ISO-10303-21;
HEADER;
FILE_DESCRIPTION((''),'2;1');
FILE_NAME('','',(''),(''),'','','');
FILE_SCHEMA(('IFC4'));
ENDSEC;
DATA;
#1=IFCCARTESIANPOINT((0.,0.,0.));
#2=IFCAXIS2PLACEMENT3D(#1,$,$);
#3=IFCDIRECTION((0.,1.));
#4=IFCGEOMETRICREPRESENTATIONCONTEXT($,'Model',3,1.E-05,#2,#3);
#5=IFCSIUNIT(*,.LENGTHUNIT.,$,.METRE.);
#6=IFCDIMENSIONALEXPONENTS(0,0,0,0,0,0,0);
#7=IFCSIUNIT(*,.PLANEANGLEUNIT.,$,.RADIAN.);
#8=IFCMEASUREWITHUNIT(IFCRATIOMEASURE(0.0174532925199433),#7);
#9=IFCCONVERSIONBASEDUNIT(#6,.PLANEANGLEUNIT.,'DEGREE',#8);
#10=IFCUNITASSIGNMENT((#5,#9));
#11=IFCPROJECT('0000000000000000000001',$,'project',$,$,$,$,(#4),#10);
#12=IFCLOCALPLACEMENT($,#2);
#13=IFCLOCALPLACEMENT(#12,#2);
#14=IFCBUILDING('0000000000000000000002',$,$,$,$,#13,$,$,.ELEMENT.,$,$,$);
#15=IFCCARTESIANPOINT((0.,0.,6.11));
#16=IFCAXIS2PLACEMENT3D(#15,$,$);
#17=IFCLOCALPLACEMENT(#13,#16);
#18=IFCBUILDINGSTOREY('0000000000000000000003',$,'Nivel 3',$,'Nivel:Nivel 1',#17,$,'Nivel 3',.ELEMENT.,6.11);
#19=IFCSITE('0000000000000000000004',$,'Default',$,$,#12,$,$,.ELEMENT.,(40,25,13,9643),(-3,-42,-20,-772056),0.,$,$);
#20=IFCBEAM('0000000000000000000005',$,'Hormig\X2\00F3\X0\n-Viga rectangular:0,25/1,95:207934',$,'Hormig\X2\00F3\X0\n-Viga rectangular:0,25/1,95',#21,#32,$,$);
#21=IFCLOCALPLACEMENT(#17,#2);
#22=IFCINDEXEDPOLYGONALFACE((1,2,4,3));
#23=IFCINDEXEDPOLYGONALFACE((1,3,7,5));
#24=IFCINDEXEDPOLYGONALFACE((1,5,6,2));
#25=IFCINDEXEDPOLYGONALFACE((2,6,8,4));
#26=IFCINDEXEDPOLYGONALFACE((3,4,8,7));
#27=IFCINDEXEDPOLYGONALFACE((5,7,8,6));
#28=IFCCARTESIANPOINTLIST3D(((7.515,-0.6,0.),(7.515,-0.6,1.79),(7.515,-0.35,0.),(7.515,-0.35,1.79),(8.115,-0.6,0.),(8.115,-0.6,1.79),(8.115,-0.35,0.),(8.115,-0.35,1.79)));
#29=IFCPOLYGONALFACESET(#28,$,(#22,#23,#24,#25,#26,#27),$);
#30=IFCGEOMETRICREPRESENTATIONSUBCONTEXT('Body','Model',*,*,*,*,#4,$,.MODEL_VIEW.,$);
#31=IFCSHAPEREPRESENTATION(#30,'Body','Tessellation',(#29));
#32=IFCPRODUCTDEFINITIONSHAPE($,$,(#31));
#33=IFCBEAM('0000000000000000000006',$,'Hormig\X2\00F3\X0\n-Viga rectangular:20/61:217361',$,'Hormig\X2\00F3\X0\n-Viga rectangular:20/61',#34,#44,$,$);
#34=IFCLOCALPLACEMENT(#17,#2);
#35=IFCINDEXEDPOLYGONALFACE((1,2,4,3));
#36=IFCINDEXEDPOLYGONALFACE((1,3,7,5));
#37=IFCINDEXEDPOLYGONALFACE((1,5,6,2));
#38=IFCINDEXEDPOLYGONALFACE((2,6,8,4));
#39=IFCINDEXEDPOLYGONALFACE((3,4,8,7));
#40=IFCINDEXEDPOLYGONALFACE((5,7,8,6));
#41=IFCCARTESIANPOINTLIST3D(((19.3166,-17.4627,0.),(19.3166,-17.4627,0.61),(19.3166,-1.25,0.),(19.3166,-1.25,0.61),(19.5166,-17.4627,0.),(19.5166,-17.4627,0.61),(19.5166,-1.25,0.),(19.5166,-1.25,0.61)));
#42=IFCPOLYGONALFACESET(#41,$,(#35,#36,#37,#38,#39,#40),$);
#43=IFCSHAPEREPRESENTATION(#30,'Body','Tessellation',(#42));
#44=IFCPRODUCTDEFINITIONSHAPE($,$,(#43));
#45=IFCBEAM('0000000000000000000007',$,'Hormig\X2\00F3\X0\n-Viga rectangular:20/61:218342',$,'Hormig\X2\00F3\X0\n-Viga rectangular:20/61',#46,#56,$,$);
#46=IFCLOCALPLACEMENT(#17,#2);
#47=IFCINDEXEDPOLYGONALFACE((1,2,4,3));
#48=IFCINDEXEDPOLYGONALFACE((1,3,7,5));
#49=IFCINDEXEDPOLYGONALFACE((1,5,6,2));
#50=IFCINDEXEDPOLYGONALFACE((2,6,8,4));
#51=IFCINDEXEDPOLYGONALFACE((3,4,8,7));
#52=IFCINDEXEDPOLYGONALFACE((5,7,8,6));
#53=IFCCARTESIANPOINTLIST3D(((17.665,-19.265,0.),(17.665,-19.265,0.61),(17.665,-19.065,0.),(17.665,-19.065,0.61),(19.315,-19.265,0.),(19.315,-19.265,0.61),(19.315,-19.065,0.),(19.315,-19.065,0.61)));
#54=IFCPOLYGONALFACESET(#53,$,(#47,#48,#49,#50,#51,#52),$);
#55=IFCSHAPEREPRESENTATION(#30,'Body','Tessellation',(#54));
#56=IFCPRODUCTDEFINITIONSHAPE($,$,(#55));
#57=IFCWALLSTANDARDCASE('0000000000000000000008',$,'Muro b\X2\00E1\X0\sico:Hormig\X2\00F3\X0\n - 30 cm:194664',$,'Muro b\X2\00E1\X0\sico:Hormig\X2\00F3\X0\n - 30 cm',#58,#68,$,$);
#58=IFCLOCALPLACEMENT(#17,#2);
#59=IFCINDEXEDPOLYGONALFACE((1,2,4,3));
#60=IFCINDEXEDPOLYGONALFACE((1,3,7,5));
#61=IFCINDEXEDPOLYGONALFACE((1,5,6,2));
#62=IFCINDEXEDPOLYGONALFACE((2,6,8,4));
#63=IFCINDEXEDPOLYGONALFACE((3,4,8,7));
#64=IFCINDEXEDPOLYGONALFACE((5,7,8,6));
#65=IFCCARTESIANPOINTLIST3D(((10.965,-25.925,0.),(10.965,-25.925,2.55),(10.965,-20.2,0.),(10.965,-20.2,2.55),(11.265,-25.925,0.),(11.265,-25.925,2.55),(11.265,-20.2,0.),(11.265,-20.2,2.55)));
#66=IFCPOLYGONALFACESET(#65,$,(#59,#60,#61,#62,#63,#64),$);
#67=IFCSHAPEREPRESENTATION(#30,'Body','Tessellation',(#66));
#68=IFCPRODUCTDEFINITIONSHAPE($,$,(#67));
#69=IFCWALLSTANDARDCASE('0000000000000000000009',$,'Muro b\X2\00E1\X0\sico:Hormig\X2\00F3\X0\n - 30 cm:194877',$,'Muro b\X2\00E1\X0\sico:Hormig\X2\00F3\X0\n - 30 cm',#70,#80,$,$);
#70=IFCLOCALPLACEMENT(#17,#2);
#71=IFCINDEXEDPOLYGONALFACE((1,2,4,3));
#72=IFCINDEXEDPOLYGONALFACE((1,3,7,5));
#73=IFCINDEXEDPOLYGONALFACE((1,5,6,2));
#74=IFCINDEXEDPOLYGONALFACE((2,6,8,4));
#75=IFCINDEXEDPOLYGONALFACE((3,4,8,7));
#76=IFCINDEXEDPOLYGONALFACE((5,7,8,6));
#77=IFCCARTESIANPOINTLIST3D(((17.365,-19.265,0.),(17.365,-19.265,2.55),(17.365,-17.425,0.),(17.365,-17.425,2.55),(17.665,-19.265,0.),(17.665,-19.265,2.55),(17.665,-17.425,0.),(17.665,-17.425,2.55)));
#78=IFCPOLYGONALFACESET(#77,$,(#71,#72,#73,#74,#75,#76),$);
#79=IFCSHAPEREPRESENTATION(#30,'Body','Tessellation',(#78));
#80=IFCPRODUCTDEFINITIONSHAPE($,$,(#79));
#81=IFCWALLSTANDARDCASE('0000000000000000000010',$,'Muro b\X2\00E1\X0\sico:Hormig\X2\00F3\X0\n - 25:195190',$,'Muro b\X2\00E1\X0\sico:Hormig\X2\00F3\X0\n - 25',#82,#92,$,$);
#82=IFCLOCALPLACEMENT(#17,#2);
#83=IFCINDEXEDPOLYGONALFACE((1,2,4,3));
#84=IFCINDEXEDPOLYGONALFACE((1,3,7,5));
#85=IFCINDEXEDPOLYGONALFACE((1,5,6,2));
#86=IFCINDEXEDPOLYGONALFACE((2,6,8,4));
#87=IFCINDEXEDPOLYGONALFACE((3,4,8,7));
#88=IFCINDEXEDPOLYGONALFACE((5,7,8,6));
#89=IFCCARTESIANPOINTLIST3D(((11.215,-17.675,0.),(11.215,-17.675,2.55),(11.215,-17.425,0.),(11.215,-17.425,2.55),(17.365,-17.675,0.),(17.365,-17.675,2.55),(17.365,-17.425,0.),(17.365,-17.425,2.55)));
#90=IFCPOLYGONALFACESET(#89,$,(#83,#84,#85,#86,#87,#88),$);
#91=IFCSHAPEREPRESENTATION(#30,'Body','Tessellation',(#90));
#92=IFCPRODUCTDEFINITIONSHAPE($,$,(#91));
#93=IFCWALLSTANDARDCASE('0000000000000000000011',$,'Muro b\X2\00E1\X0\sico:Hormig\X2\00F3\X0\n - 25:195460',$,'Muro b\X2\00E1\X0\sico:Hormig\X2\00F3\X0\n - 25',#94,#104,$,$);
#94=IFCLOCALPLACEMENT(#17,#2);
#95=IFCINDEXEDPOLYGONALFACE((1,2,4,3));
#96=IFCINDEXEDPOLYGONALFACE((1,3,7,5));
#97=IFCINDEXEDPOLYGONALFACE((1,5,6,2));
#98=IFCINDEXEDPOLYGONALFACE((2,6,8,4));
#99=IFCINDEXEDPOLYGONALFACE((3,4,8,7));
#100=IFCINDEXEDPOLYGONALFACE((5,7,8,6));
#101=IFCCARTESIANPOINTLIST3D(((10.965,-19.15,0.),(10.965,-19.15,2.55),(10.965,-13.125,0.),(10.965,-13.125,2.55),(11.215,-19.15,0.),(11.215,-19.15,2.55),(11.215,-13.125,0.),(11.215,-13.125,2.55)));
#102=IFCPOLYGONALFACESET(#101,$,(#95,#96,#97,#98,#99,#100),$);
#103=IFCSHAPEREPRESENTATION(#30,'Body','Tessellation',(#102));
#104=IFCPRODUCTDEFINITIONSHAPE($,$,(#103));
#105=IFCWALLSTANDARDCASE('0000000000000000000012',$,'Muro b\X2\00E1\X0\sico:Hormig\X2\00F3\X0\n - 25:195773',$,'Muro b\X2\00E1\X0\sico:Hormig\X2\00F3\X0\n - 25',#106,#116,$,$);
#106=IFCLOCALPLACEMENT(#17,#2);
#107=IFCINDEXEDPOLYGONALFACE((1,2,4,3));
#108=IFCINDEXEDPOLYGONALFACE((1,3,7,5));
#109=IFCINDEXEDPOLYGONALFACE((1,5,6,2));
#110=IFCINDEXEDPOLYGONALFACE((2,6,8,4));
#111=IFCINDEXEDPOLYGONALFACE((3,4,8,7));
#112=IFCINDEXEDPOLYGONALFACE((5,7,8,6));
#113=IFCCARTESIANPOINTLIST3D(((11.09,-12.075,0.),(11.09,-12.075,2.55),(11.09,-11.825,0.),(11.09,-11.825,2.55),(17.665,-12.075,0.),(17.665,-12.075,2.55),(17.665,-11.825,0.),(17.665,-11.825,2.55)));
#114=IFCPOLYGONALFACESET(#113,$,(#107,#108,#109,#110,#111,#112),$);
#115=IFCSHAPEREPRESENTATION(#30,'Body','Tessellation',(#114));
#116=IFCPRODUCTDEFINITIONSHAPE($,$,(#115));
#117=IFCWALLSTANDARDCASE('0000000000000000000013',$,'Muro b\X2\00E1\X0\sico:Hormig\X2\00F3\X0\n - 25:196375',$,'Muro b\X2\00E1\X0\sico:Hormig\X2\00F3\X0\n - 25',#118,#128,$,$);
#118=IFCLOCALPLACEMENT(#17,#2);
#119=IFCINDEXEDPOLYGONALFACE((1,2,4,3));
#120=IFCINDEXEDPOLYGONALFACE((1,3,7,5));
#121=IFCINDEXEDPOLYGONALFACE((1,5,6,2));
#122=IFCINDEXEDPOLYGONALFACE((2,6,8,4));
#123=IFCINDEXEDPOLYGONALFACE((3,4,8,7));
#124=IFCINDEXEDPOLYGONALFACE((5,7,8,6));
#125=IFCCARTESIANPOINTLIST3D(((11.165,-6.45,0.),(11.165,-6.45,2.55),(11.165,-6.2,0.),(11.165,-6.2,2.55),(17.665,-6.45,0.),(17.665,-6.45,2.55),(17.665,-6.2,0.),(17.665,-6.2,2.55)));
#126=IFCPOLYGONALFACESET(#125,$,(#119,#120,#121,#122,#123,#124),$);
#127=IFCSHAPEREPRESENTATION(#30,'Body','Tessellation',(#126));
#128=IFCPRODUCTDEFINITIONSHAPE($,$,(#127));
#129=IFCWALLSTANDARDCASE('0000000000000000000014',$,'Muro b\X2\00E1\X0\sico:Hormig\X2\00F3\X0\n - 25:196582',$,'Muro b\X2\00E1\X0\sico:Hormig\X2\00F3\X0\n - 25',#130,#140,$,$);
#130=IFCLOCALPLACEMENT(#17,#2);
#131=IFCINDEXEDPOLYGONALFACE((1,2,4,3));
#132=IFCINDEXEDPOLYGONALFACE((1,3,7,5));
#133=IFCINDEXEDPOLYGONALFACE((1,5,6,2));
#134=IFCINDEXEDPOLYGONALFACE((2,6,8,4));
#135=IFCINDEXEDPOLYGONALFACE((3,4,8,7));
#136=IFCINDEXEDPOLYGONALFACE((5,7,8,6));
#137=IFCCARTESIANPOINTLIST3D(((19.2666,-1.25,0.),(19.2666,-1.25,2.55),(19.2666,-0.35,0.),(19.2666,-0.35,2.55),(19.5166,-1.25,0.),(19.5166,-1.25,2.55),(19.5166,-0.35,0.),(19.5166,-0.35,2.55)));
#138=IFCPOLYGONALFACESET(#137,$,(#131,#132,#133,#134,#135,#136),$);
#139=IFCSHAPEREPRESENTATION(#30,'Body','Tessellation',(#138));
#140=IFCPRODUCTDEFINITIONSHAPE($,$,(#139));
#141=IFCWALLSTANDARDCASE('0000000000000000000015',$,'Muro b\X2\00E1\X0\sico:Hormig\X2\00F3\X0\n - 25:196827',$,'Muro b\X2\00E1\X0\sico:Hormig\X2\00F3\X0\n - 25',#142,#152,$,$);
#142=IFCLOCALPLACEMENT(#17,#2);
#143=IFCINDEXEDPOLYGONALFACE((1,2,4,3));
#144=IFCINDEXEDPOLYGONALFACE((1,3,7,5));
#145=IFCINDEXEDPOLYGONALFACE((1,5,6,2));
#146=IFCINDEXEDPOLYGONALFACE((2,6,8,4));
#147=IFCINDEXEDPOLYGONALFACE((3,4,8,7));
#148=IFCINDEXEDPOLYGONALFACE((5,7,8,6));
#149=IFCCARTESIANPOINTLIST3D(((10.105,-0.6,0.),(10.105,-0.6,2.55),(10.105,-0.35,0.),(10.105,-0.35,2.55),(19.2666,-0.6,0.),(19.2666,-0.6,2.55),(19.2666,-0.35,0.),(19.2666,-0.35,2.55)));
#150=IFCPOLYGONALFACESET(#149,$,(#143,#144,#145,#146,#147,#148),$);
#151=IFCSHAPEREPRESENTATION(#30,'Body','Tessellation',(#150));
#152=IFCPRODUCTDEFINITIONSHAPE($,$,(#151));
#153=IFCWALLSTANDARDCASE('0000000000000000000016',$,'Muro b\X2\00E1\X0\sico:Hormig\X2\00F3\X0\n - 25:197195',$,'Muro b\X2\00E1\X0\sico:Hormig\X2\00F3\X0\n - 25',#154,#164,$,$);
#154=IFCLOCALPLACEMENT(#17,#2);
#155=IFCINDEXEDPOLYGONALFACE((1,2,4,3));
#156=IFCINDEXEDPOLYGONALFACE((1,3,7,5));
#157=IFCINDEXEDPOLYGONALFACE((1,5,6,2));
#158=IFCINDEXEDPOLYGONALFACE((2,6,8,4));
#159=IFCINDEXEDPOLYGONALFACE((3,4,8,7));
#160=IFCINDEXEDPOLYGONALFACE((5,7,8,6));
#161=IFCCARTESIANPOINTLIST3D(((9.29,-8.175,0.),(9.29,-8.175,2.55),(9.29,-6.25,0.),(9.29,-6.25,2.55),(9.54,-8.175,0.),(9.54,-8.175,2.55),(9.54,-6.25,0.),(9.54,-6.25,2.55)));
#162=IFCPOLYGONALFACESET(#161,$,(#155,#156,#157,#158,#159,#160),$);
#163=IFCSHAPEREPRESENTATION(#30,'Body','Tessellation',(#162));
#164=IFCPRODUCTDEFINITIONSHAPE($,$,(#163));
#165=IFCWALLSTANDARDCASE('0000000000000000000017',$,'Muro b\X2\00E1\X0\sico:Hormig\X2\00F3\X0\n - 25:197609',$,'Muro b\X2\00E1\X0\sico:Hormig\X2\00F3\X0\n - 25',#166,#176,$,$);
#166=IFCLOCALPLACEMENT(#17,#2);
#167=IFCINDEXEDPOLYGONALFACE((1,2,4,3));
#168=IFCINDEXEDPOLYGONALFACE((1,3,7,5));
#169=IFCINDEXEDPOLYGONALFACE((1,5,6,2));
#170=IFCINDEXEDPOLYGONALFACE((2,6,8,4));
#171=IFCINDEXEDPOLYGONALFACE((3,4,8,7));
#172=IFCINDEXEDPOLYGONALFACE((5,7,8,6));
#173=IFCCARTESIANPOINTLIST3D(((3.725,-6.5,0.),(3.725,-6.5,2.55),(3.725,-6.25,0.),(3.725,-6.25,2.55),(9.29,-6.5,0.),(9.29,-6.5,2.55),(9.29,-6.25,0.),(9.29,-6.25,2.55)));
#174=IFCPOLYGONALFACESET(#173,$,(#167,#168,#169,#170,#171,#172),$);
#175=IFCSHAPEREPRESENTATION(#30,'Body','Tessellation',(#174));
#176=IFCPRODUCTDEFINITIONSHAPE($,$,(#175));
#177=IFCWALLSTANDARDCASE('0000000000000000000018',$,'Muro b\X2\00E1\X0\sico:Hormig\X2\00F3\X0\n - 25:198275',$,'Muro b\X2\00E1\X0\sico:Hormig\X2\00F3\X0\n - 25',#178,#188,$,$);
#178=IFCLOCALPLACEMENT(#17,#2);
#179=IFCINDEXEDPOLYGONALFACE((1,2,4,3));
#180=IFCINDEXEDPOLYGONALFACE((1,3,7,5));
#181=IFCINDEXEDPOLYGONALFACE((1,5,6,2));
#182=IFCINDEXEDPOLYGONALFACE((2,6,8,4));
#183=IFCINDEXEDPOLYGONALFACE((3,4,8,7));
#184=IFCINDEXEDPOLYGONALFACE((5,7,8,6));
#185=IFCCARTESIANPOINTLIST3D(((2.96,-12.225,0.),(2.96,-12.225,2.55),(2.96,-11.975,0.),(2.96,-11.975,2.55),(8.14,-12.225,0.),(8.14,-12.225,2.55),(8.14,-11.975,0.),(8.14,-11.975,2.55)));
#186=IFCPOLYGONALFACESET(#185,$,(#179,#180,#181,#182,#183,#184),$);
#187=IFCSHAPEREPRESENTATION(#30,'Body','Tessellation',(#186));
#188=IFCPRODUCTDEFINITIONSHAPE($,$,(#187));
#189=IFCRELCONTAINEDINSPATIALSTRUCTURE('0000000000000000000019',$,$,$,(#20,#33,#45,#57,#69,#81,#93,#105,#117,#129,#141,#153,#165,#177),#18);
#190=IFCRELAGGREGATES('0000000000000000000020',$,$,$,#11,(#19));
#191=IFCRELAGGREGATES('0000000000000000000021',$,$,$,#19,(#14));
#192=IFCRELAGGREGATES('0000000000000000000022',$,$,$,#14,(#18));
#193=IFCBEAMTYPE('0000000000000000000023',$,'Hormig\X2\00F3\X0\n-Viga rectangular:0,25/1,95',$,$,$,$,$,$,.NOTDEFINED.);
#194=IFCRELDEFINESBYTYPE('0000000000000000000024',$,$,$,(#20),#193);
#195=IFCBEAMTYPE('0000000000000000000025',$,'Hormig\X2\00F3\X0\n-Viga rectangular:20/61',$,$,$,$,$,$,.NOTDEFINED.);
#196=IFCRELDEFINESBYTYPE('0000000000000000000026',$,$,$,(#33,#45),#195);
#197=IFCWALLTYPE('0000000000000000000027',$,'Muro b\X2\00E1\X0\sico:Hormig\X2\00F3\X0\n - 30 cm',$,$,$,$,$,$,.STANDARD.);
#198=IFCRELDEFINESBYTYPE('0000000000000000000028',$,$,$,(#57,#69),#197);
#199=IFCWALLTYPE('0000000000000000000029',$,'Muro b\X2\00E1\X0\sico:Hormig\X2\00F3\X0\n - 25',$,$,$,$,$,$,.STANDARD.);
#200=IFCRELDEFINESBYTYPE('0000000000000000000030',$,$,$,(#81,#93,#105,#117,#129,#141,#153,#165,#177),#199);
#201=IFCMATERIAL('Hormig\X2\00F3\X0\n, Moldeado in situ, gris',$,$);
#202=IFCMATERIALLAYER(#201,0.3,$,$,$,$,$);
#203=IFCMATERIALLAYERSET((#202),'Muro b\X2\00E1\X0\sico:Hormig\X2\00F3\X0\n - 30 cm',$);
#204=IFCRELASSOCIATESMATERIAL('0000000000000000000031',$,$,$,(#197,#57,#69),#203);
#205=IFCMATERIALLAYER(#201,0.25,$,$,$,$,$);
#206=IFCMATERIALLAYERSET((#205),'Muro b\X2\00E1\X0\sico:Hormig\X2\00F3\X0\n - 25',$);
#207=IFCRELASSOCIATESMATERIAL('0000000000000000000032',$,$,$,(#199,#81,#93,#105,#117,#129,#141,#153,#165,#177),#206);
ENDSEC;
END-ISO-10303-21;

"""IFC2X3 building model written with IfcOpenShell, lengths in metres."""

from ifc_helpers import new_model, entity, si_unit, converted_unit, direction, frame, frame_2d, origin, origin_2d_with_axis, place, context, subcontext, project, spatial, rectangle, extrude, material, layer, layer_set, layer_usage, type_object, element, save


model = new_model("IFC2X3")

# Units and contexts
model_context = context("Model", 3, precision=1e-05, world=origin(), true_north=direction((0.0, 1.0)))
body_context = subcontext(model_context, "Body", "Model", "MODEL_VIEW")
ifc_project = project(units=[si_unit("LENGTHUNIT", "METRE"), converted_unit("PLANEANGLEUNIT", "DEGREE", entity("IfcRatioMeasure", 0.0174532925199433), si_unit("PLANEANGLEUNIT", "RADIAN"), dimensions=[0, 0, 0, 0, 0, 0, 0])], contexts=[model_context])

# Site, building, storey
site_placement = place(None, origin())
site = spatial("IfcSite", under=ifc_project, at=site_placement, Name="Default", CompositionType="ELEMENT", RefLatitude=(40, 25, 13, 9643), RefLongitude=(-3, -42, -20, -772056), RefElevation=0.0)
building_placement = place(site_placement, origin())
building = spatial("IfcBuilding", under=site, at=building_placement, CompositionType="ELEMENT")
storey_placement = place(building_placement, frame((0.0, 0.0, 6.11)))
storey = spatial("IfcBuildingStorey", under=building, at=storey_placement, Name="Nivel 3", ObjectType="Nivel:Nivel 1", LongName="Nivel 3", CompositionType="ELEMENT", Elevation=6.11)

# Beams
beam_type_1 = type_object("IfcBeamType", Name="Hormigón-Viga rectangular:0,25/1,95", PredefinedType="NOTDEFINED")
beam_1_placement = place(storey_placement, frame((7.515, -0.475, 1.79)))
element("IfcBeam", 1, at=beam_1_placement, inside=storey, type_object=beam_type_1, Name="Hormigón-Viga rectangular:0,25/1,95:207934", ObjectType="Hormigón-Viga rectangular:0,25/1,95", context=body_context, shape_type="SweptSolid", body=[
    extrude(rectangle(XDim=1.79, YDim=0.25, at=frame_2d((0.0, 0.0), x_axis=(1.0, 0.0))), frame((0.0, 0.0, -0.895), z_axis=(1.0, 0.0, 0.0), x_axis=(0.0, 0.0, -1.0)), (0.0, 0.0, 1.0), 0.6),
])
beam_type_2 = type_object("IfcBeamType", Name="Hormigón-Viga rectangular:20/61", PredefinedType="NOTDEFINED")
beam_2_placement = place(storey_placement, frame((19.4166, -17.45, 0.61), z_axis=(0.0, 0.0, 1.0), x_axis=(0.0, 1.0, 0.0)))
element("IfcBeam", 2, at=beam_2_placement, inside=storey, type_object=beam_type_2, Name="Hormigón-Viga rectangular:20/61:217361", ObjectType="Hormigón-Viga rectangular:20/61", context=body_context, shape_type="SweptSolid", body=[
    extrude(rectangle(XDim=0.61, YDim=0.2, at=origin_2d_with_axis()), frame((-0.0127, 0.0, -0.305), z_axis=(1.0, 0.0, 0.0), x_axis=(0.0, 0.0, -1.0)), (0.0, 0.0, 1.0), 16.2127),
])
beam_3_placement = place(storey_placement, frame((17.515, -19.165, 0.61)))
element("IfcBeam", 3, at=beam_3_placement, inside=storey, type_object=beam_type_2, Name="Hormigón-Viga rectangular:20/61:218342", ObjectType="Hormigón-Viga rectangular:20/61", context=body_context, shape_type="SweptSolid", body=[
    extrude(rectangle(XDim=0.61, YDim=0.2, at=frame_2d((0.0, 0.0), x_axis=(1.0, 0.0))), frame((0.15, 0.0, -0.305), z_axis=(1.0, 0.0, 0.0), x_axis=(0.0, 0.0, -1.0)), (0.0, 0.0, 1.0), 1.65),
])

# Walls
ifc_material = material(Name="Hormigón, Moldeado in situ, gris")
ifc_layer_1 = layer(ifc_material, 0.3)
ifc_layer_set_1 = layer_set([ifc_layer_1], Name="Muro básico:Hormigón - 30 cm")
ifc_layer_usage_1 = layer_usage(ifc_layer_set_1, "AXIS2", "NEGATIVE", 0.15)
wall_type_1 = type_object("IfcWallType", Name="Muro básico:Hormigón - 30 cm", PredefinedType="STANDARD", material=ifc_layer_set_1)
wall_1_placement = place(storey_placement, frame((11.115, -20.2, 0.0), z_axis=(0.0, 0.0, 1.0), x_axis=(0.0, -1.0, 0.0)))
element("IfcWallStandardCase", 4, at=wall_1_placement, inside=storey, type_object=wall_type_1, material=ifc_layer_usage_1, Name="Muro básico:Hormigón - 30 cm:194664", ObjectType="Muro básico:Hormigón - 30 cm", context=body_context, shape_type="SweptSolid", body=[
    extrude(rectangle(XDim=5.725, YDim=0.3, at=frame_2d((2.8625, 0.0), x_axis=(-1.0, 0.0))), origin(), (0.0, 0.0, 1.0), 2.55),
])
ifc_layer_usage_2 = layer_usage(ifc_layer_set_1, "AXIS2", "NEGATIVE", 0.15)
wall_2_placement = place(storey_placement, frame((17.515, -19.265, 0.0), z_axis=(0.0, 0.0, 1.0), x_axis=(0.0, 1.0, 0.0)))
element("IfcWallStandardCase", 5, at=wall_2_placement, inside=storey, type_object=wall_type_1, material=ifc_layer_usage_2, Name="Muro básico:Hormigón - 30 cm:194877", ObjectType="Muro básico:Hormigón - 30 cm", context=body_context, shape_type="SweptSolid", body=[
    extrude(rectangle(XDim=1.84, YDim=0.3, at=frame_2d((0.92, 0.0), x_axis=(-1.0, 0.0))), origin(), (0.0, 0.0, 1.0), 2.55),
])
ifc_layer_2 = layer(ifc_material, 0.25)
ifc_layer_set_2 = layer_set([ifc_layer_2], Name="Muro básico:Hormigón - 25")
ifc_layer_usage_3 = layer_usage(ifc_layer_set_2, "AXIS2", "NEGATIVE", 0.125)
wall_type_2 = type_object("IfcWallType", Name="Muro básico:Hormigón - 25", PredefinedType="STANDARD", material=ifc_layer_set_2)
wall_3_placement = place(storey_placement, frame((17.365, -17.55, 0.0), z_axis=(0.0, 0.0, 1.0), x_axis=(-1.0, 0.0, 0.0)))
element("IfcWallStandardCase", 6, at=wall_3_placement, inside=storey, type_object=wall_type_2, material=ifc_layer_usage_3, Name="Muro básico:Hormigón - 25:195190", ObjectType="Muro básico:Hormigón - 25", context=body_context, shape_type="SweptSolid", body=[
    extrude(rectangle(XDim=6.15, YDim=0.25, at=frame_2d((3.075, 0.0), x_axis=(-1.0, 0.0))), origin(), (0.0, 0.0, 1.0), 2.55),
])
ifc_layer_usage_4 = layer_usage(ifc_layer_set_2, "AXIS2", "NEGATIVE", 0.125)
wall_4_placement = place(storey_placement, frame((11.09, -19.15, 0.0), z_axis=(0.0, 0.0, 1.0), x_axis=(0.0, 1.0, 0.0)))
element("IfcWallStandardCase", 7, at=wall_4_placement, inside=storey, type_object=wall_type_2, material=ifc_layer_usage_4, Name="Muro básico:Hormigón - 25:195460", ObjectType="Muro básico:Hormigón - 25", context=body_context, shape_type="SweptSolid", body=[
    extrude(rectangle(XDim=6.025, YDim=0.25, at=frame_2d((3.0125, 0.0), x_axis=(-1.0, 0.0))), origin(), (0.0, 0.0, 1.0), 2.55),
])
ifc_layer_usage_5 = layer_usage(ifc_layer_set_2, "AXIS2", "NEGATIVE", 0.125)
wall_5_placement = place(storey_placement, frame((11.09, -11.95, 0.0)))
element("IfcWallStandardCase", 8, at=wall_5_placement, inside=storey, type_object=wall_type_2, material=ifc_layer_usage_5, Name="Muro básico:Hormigón - 25:195773", ObjectType="Muro básico:Hormigón - 25", context=body_context, shape_type="SweptSolid", body=[
    extrude(rectangle(XDim=6.575, YDim=0.25, at=frame_2d((3.2875, 0.0), x_axis=(-1.0, 0.0))), origin(), (0.0, 0.0, 1.0), 2.55),
])
ifc_layer_usage_6 = layer_usage(ifc_layer_set_2, "AXIS2", "NEGATIVE", 0.125)
wall_6_placement = place(storey_placement, frame((17.665, -6.325, 0.0), z_axis=(0.0, 0.0, 1.0), x_axis=(-1.0, 0.0, 0.0)))
element("IfcWallStandardCase", 9, at=wall_6_placement, inside=storey, type_object=wall_type_2, material=ifc_layer_usage_6, Name="Muro básico:Hormigón - 25:196375", ObjectType="Muro básico:Hormigón - 25", context=body_context, shape_type="SweptSolid", body=[
    extrude(rectangle(XDim=6.5, YDim=0.25, at=frame_2d((3.25, 0.0), x_axis=(-1.0, 0.0))), origin(), (0.0, 0.0, 1.0), 2.55),
])
ifc_layer_usage_7 = layer_usage(ifc_layer_set_2, "AXIS2", "NEGATIVE", 0.125)
wall_7_placement = place(storey_placement, frame((19.3916, -1.25, 0.0), z_axis=(0.0, 0.0, 1.0), x_axis=(0.0, 1.0, 0.0)))
element("IfcWallStandardCase", 10, at=wall_7_placement, inside=storey, type_object=wall_type_2, material=ifc_layer_usage_7, Name="Muro básico:Hormigón - 25:196582", ObjectType="Muro básico:Hormigón - 25", context=body_context, shape_type="SweptSolid", body=[
    extrude(rectangle(XDim=0.9, YDim=0.25, at=frame_2d((0.45, 0.0), x_axis=(-1.0, 0.0))), origin(), (0.0, 0.0, 1.0), 2.55),
])
ifc_layer_usage_8 = layer_usage(ifc_layer_set_2, "AXIS2", "NEGATIVE", 0.125)
wall_8_placement = place(storey_placement, frame((10.105, -0.475, 0.0)))
element("IfcWallStandardCase", 11, at=wall_8_placement, inside=storey, type_object=wall_type_2, material=ifc_layer_usage_8, Name="Muro básico:Hormigón - 25:196827", ObjectType="Muro básico:Hormigón - 25", context=body_context, shape_type="SweptSolid", body=[
    extrude(rectangle(XDim=9.1616, YDim=0.25, at=frame_2d((4.5808, 0.0), x_axis=(-1.0, 0.0))), origin(), (0.0, 0.0, 1.0), 2.55),
])
ifc_layer_usage_9 = layer_usage(ifc_layer_set_2, "AXIS2", "NEGATIVE", 0.125)
wall_9_placement = place(storey_placement, frame((9.415, -8.175, 0.0), z_axis=(0.0, 0.0, 1.0), x_axis=(0.0, 1.0, 0.0)))
element("IfcWallStandardCase", 12, at=wall_9_placement, inside=storey, type_object=wall_type_2, material=ifc_layer_usage_9, Name="Muro básico:Hormigón - 25:197195", ObjectType="Muro básico:Hormigón - 25", context=body_context, shape_type="SweptSolid", body=[
    extrude(rectangle(XDim=1.925, YDim=0.25, at=frame_2d((0.9625, 0.0), x_axis=(-1.0, 0.0))), origin(), (0.0, 0.0, 1.0), 2.55),
])
ifc_layer_usage_10 = layer_usage(ifc_layer_set_2, "AXIS2", "NEGATIVE", 0.125)
wall_10_placement = place(storey_placement, frame((3.725, -6.375, 0.0)))
element("IfcWallStandardCase", 13, at=wall_10_placement, inside=storey, type_object=wall_type_2, material=ifc_layer_usage_10, Name="Muro básico:Hormigón - 25:197609", ObjectType="Muro básico:Hormigón - 25", context=body_context, shape_type="SweptSolid", body=[
    extrude(rectangle(XDim=5.565, YDim=0.25, at=frame_2d((2.7825, 0.0), x_axis=(-1.0, 0.0))), origin(), (0.0, 0.0, 1.0), 2.55),
])
ifc_layer_usage_11 = layer_usage(ifc_layer_set_2, "AXIS2", "NEGATIVE", 0.125)
wall_11_placement = place(storey_placement, frame((8.14, -12.1, 0.0), z_axis=(0.0, 0.0, 1.0), x_axis=(-1.0, 0.0, 0.0)))
element("IfcWallStandardCase", 14, at=wall_11_placement, inside=storey, type_object=wall_type_2, material=ifc_layer_usage_11, Name="Muro básico:Hormigón - 25:198275", ObjectType="Muro básico:Hormigón - 25", context=body_context, shape_type="SweptSolid", body=[
    extrude(rectangle(XDim=5.18, YDim=0.25, at=frame_2d((2.59, 0.0), x_axis=(-1.0, 0.0))), origin(), (0.0, 0.0, 1.0), 2.55),
])

save(model, "model.ifc")
